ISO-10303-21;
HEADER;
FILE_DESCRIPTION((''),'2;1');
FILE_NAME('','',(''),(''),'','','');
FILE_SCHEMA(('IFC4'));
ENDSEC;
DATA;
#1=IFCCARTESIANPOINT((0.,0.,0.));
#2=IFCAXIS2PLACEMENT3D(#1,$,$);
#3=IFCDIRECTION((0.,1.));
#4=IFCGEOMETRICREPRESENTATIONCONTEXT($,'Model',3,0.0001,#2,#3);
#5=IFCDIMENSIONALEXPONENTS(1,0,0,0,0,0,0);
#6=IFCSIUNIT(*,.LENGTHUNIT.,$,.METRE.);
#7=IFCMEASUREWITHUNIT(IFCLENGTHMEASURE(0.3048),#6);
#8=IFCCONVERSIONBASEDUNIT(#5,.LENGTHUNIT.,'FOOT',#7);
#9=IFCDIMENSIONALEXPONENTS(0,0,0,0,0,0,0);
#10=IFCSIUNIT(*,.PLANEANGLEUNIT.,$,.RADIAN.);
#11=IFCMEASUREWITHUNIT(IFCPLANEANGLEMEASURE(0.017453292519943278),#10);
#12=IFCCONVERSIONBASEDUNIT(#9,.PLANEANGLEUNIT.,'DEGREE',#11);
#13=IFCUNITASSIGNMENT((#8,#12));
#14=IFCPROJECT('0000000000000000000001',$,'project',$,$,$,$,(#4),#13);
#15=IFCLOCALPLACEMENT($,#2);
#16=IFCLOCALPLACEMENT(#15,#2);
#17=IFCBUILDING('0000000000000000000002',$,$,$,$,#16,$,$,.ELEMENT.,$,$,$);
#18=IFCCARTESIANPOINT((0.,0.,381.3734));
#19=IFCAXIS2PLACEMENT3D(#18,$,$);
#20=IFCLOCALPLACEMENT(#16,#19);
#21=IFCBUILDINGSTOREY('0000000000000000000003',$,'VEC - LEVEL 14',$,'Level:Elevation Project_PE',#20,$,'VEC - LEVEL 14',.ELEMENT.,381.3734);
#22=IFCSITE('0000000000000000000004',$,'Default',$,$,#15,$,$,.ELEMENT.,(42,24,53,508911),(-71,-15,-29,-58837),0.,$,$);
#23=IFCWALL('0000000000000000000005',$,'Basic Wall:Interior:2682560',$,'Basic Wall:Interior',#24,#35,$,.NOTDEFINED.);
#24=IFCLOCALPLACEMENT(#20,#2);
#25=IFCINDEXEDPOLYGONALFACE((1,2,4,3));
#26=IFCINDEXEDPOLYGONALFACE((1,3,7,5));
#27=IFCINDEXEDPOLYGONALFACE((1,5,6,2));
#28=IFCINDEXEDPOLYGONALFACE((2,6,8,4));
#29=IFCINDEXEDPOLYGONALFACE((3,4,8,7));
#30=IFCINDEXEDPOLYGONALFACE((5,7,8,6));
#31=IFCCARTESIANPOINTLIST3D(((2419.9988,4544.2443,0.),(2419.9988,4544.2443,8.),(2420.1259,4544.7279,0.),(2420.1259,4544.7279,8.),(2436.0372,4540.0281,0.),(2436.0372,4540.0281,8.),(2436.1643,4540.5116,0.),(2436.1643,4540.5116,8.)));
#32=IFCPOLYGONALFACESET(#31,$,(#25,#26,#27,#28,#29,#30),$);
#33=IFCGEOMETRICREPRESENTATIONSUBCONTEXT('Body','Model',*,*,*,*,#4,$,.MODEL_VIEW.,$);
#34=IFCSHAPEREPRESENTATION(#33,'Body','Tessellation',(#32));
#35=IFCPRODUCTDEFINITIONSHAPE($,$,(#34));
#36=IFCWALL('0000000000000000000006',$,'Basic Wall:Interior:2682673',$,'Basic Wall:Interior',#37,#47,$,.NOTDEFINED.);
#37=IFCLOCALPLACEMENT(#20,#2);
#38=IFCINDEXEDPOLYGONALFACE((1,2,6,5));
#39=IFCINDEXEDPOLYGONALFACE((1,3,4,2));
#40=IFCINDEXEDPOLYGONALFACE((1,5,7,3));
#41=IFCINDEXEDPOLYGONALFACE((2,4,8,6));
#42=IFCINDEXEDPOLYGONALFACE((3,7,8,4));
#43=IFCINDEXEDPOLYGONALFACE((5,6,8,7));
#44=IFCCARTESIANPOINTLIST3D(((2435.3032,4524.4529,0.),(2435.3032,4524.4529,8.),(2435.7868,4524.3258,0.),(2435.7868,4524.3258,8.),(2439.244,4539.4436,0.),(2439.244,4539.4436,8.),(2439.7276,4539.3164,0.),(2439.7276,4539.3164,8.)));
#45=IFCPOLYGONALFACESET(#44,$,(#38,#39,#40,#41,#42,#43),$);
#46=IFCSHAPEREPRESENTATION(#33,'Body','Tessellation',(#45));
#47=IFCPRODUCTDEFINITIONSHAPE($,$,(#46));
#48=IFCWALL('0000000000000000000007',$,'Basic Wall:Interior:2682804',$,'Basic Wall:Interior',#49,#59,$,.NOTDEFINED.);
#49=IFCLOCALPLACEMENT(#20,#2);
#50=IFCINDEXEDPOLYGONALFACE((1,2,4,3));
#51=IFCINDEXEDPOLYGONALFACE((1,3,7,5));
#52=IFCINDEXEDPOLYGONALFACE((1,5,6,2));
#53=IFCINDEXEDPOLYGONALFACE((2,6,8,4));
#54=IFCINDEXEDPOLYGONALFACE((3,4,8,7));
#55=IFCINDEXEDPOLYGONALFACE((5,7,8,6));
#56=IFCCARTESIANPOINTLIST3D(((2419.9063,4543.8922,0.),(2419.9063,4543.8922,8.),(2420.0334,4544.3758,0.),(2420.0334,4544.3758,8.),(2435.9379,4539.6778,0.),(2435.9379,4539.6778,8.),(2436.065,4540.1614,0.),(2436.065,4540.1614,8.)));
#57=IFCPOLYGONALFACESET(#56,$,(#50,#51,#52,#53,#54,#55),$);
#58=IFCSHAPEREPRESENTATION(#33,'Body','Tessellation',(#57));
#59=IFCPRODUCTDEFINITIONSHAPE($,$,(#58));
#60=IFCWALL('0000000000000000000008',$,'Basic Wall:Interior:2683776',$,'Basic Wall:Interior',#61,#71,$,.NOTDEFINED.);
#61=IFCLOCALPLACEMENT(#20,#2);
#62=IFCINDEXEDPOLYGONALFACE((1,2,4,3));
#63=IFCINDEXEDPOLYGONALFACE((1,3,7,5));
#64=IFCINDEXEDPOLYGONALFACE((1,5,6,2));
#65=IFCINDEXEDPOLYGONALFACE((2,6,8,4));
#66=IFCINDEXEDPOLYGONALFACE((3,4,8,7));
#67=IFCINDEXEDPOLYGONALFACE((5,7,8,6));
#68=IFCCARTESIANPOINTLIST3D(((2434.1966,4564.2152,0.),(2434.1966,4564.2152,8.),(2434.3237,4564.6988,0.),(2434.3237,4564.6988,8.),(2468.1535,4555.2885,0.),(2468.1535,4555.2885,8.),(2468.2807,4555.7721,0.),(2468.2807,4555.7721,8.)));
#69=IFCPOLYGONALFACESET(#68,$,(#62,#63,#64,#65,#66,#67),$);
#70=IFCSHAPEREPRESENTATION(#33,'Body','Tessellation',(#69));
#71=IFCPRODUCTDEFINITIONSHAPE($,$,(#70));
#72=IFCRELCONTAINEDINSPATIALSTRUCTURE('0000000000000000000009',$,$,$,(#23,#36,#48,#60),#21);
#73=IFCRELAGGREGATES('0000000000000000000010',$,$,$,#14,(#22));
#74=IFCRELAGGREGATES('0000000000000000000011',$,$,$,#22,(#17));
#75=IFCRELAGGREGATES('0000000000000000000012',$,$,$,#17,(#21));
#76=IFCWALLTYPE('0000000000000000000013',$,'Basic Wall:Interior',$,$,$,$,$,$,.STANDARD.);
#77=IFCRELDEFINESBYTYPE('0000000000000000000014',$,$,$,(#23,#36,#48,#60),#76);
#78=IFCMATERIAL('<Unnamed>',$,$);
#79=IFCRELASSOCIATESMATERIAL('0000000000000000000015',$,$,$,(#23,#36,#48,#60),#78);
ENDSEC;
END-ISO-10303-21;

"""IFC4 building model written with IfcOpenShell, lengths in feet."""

from ifc_helpers import new_model, entity, si_unit, converted_unit, direction, frame, origin, place, context, subcontext, project, spatial, indexed_curve, outline, extrude, material, type_object, element, save


model = new_model("IFC4")

# Units and contexts
model_context = context("Model", 3, precision=0.0001, world=origin(), true_north=direction((0.0, 1.0)))
body_context = subcontext(model_context, "Body", "Model", "MODEL_VIEW")
ifc_project = project(units=[converted_unit("LENGTHUNIT", "FOOT", entity("IfcLengthMeasure", 0.3048), si_unit("LENGTHUNIT", "METRE"), dimensions=[1, 0, 0, 0, 0, 0, 0]), converted_unit("PLANEANGLEUNIT", "DEGREE", entity("IfcPlaneAngleMeasure", 0.017453292519943278), si_unit("PLANEANGLEUNIT", "RADIAN"), dimensions=[0, 0, 0, 0, 0, 0, 0])], contexts=[model_context])

# Site, building, storey
site_placement = place(None, origin())
site = spatial("IfcSite", under=ifc_project, at=site_placement, Name="Default", CompositionType="ELEMENT", RefLatitude=(42, 24, 53, 508911), RefLongitude=(-71, -15, -29, -58837), RefElevation=0.0)
building_placement = place(site_placement, origin())
building = spatial("IfcBuilding", under=site, at=building_placement, CompositionType="ELEMENT")
storey_placement = place(building_placement, frame((0.0, 0.0, 381.3734)))
storey = spatial("IfcBuildingStorey", under=building, at=storey_placement, Name="VEC - LEVEL 14", ObjectType="Level:Elevation Project_PE", LongName="VEC - LEVEL 14", CompositionType="ELEMENT", Elevation=381.3734)

# Walls
ifc_material_1 = material(Name="<Unnamed>")
wall_type = type_object("IfcWallType", Name="Basic Wall:Interior", PredefinedType="STANDARD")
wall_1_placement = place(storey_placement, frame((2420.0624, 4544.4861, 0.0), z_axis=(0.0, 0.0, 1.0), x_axis=(0.96714, -0.254244, 0.0)))
element("IfcWall", 1, at=wall_1_placement, inside=storey, type_object=wall_type, material=ifc_material_1, Name="Basic Wall:Interior:2682560", ObjectType="Basic Wall:Interior", PredefinedType="NOTDEFINED", context=body_context, shape_type="SweptSolid", body=[
    extrude(outline(indexed_curve([(16.5833, 0.25), (0.0, 0.25), (0.0, -0.25), (16.5833, -0.25), (16.5833, 0.25)], self_intersect=False)), origin(), (0.0, 0.0, 1.0), 8.0),
])
wall_2_placement = place(storey_placement, frame((2439.4858, 4539.38, 0.0), z_axis=(0.0, 0.0, 1.0), x_axis=(-0.254244, -0.96714, 0.0)))
element("IfcWall", 2, at=wall_2_placement, inside=storey, type_object=wall_type, material=ifc_material_1, Name="Basic Wall:Interior:2682673", ObjectType="Basic Wall:Interior", PredefinedType="NOTDEFINED", context=body_context, shape_type="SweptSolid", body=[
    extrude(outline(indexed_curve([(15.5, 0.25), (0.0, 0.25), (0.0, -0.25), (15.5, -0.25), (15.5, 0.25)], self_intersect=False)), origin(), (0.0, 0.0, 1.0), 8.0),
])
wall_3_placement = place(storey_placement, frame((2419.9698, 4544.134, 0.0), z_axis=(0.0, 0.0, 1.0), x_axis=(0.96714, -0.254244, 0.0)))
element("IfcWall", 3, at=wall_3_placement, inside=storey, type_object=wall_type, material=ifc_material_1, Name="Basic Wall:Interior:2682804", ObjectType="Basic Wall:Interior", PredefinedType="NOTDEFINED", context=body_context, shape_type="SweptSolid", body=[
    extrude(outline(indexed_curve([(16.5763, 0.25), (0.0, 0.25), (0.0, -0.25), (16.5763, -0.25), (16.5763, 0.25)], self_intersect=False)), origin(), (0.0, 0.0, 1.0), 8.0),
])
wall_4_placement = place(storey_placement, frame((2434.2601, 4564.457, 0.0), z_axis=(0.0, 0.0, 1.0), x_axis=(0.96714, -0.254244, 0.0)))
element("IfcWall", 4, at=wall_4_placement, inside=storey, type_object=wall_type, material=ifc_material_1, Name="Basic Wall:Interior:2683776", ObjectType="Basic Wall:Interior", PredefinedType="NOTDEFINED", context=body_context, shape_type="SweptSolid", body=[
    extrude(outline(indexed_curve([(35.1107, 0.25), (0.0, 0.25), (0.0, -0.25), (35.1107, -0.25), (35.1107, 0.25)], self_intersect=False)), origin(), (0.0, 0.0, 1.0), 8.0),
])

save(model, "model.ifc")
